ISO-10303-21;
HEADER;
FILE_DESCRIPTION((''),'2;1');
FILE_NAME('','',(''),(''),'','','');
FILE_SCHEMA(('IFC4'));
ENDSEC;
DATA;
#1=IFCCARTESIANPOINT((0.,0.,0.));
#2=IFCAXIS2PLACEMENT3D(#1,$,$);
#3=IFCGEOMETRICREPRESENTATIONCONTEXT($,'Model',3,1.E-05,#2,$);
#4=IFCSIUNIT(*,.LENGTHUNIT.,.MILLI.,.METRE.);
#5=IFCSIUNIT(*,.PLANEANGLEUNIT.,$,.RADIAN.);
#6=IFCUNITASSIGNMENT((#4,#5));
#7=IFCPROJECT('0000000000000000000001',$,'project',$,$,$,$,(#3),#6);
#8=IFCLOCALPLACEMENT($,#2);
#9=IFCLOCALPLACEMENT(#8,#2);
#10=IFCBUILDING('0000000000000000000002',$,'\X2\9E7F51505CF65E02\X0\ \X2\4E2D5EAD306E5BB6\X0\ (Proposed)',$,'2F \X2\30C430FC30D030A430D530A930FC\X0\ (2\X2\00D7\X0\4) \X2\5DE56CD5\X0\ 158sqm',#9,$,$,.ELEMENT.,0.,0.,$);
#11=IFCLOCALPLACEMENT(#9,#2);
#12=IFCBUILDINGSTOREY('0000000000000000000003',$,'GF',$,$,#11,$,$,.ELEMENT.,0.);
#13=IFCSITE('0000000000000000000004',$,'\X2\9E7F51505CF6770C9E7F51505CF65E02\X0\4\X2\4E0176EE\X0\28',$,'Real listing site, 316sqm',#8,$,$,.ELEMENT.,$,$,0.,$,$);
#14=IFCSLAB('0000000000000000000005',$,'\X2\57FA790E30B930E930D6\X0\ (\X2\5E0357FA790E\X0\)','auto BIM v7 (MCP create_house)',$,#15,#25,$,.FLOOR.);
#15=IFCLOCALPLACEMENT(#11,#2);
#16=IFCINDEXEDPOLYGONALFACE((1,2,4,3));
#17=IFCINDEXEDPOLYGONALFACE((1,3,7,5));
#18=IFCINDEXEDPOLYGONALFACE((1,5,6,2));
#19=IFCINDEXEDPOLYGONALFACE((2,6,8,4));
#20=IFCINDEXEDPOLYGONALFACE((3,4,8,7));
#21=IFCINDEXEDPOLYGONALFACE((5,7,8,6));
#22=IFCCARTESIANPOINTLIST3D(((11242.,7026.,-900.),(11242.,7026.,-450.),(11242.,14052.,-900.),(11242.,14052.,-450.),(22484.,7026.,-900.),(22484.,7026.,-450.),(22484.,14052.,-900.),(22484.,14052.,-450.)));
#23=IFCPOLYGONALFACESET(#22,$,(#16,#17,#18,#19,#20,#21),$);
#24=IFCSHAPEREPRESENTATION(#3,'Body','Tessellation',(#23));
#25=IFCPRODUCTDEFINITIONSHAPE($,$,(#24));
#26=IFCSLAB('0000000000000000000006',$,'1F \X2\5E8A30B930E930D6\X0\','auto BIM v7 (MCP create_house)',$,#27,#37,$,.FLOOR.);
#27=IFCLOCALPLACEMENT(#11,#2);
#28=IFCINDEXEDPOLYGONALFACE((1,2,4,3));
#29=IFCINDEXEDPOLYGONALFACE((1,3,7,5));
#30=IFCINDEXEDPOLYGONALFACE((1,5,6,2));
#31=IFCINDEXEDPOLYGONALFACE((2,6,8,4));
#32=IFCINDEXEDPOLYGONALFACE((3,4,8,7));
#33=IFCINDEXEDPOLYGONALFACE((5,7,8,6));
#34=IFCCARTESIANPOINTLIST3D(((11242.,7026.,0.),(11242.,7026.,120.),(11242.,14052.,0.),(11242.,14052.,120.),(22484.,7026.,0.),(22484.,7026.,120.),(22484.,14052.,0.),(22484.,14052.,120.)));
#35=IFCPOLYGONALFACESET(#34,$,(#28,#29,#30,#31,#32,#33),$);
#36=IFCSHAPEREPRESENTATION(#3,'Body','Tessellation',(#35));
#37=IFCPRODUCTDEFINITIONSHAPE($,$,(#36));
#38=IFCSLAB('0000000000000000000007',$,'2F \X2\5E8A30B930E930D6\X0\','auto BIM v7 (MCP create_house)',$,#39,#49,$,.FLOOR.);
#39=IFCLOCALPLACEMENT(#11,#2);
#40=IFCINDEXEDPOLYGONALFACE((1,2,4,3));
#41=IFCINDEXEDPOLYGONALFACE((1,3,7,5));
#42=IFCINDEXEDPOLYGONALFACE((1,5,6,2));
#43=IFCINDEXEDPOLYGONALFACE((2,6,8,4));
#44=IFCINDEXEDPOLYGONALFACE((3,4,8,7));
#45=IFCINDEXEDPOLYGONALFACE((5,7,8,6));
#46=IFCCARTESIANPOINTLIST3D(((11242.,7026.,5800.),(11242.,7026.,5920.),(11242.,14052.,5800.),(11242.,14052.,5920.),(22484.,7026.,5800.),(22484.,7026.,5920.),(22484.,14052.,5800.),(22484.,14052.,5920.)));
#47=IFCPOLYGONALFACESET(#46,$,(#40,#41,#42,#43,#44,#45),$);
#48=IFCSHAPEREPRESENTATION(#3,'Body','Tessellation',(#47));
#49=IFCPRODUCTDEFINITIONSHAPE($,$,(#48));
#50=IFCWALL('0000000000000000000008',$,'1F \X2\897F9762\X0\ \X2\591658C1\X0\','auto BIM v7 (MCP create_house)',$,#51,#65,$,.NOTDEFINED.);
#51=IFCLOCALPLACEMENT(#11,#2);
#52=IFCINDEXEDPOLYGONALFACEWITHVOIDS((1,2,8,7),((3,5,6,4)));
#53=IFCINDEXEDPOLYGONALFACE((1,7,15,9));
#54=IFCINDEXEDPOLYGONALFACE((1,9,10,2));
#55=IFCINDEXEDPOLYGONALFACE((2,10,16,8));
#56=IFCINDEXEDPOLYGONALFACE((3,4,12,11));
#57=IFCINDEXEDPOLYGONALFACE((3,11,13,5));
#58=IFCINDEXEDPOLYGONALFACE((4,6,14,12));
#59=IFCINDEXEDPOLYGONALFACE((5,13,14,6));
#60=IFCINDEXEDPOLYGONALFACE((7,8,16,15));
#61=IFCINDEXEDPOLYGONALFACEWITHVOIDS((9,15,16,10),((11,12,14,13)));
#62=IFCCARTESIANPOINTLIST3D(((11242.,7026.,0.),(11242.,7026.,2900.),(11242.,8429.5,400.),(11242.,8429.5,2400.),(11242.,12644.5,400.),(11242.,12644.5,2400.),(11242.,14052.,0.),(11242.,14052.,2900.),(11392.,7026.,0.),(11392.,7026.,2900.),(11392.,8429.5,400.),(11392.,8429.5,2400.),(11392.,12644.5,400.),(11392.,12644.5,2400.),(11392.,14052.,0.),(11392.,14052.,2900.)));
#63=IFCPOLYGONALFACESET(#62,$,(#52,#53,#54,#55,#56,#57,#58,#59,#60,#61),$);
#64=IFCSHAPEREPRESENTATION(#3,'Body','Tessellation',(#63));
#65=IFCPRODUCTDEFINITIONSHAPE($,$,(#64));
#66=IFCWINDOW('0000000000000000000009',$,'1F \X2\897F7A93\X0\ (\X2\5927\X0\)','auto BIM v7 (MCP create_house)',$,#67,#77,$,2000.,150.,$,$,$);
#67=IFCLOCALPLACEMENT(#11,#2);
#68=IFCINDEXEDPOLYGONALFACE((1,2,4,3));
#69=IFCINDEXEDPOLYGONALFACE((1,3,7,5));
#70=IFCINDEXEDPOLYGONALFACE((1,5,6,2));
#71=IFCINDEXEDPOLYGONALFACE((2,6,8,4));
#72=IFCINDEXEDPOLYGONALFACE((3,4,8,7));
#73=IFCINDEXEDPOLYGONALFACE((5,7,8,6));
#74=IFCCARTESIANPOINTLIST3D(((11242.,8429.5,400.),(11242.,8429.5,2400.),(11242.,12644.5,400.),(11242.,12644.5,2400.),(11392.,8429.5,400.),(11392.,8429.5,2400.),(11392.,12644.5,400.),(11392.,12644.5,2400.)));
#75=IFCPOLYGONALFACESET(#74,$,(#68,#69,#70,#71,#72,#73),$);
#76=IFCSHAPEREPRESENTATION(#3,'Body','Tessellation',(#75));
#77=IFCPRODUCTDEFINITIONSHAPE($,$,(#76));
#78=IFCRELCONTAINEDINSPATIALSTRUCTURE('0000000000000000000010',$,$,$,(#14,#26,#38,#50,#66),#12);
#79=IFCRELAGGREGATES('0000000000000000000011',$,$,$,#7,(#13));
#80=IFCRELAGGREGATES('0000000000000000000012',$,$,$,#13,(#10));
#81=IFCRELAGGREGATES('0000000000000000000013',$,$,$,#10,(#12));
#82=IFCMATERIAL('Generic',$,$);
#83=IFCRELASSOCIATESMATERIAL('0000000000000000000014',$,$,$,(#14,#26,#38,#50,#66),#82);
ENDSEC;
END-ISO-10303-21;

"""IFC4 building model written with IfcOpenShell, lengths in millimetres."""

from ifc_helpers import new_model, si_unit, frame, frame_2d, origin, place, context, project, spatial, rectangle, extrude, material, element, fill, save


model = new_model("IFC4")

# Units and contexts
model_context = context("Model", 3, precision=1e-05, world=origin())
ifc_project = project(units=[si_unit("LENGTHUNIT", "METRE", prefix="MILLI"), si_unit("PLANEANGLEUNIT", "RADIAN")], contexts=[model_context])

# Site, building, storey
site_placement = place(None, origin())
site = spatial("IfcSite", under=ifc_project, at=site_placement, Name="鹿児島県鹿児島市4丁目28", ObjectType="Real listing site, 316sqm", CompositionType="ELEMENT", RefElevation=0.0)
building_placement = place(site_placement, origin())
building = spatial("IfcBuilding", under=site, at=building_placement, Name="鹿児島市 中庭の家 (Proposed)", ObjectType="2F ツーバイフォー (2×4) 工法 158sqm", CompositionType="ELEMENT", ElevationOfRefHeight=0.0, ElevationOfTerrain=0.0)
storey_placement = place(building_placement, origin())
storey = spatial("IfcBuildingStorey", under=building, at=storey_placement, Name="GF", CompositionType="ELEMENT", Elevation=0.0)

# Slabs
ifc_material = material(Name="Generic")
slab_1_placement = place(storey_placement, frame((5621.0, 3513.0, -450.0)))
element("IfcSlab", 1, at=slab_1_placement, inside=storey, material=ifc_material, Name="基礎スラブ (布基礎)", Description="auto BIM v7 (MCP create_house)", PredefinedType="FLOOR", context=model_context, shape_type="SweptSolid", body=[
    extrude(rectangle(XDim=11242.0, YDim=7026.0, at=frame_2d((5621.0, 3513.0))), frame((5621.0, 3513.0, -450.0)), (0.0, 0.0, 1.0), 450.0),
])
slab_2_placement = place(storey_placement, frame((5621.0, 3513.0, 0.0)))
element("IfcSlab", 2, at=slab_2_placement, inside=storey, material=ifc_material, Name="1F 床スラブ", Description="auto BIM v7 (MCP create_house)", PredefinedType="FLOOR", context=model_context, shape_type="SweptSolid", body=[
    extrude(rectangle(XDim=11242.0, YDim=7026.0, at=frame_2d((5621.0, 3513.0))), frame((5621.0, 3513.0, 0.0)), (0.0, 0.0, 1.0), 120.0),
])
slab_3_placement = place(storey_placement, frame((5621.0, 3513.0, 2900.0)))
element("IfcSlab", 3, at=slab_3_placement, inside=storey, material=ifc_material, Name="2F 床スラブ", Description="auto BIM v7 (MCP create_house)", PredefinedType="FLOOR", context=model_context, shape_type="SweptSolid", body=[
    extrude(rectangle(XDim=11242.0, YDim=7026.0, at=frame_2d((5621.0, 3513.0))), frame((5621.0, 3513.0, 2900.0)), (0.0, 0.0, 1.0), 120.0),
])

# Wall, opening, window
wall_1_placement = place(storey_placement, frame((5621.0, 3513.0, 0.0)))
wall_1 = element("IfcWall", 4, at=wall_1_placement, inside=storey, material=ifc_material, Name="1F 西面 外壁", Description="auto BIM v7 (MCP create_house)", PredefinedType="NOTDEFINED", context=model_context, shape_type="SweptSolid", body=[
    extrude(rectangle(XDim=150.0, YDim=7026.0, at=frame_2d((75.0, 3513.0))), frame((5621.0, 3513.0, 0.0)), (0.0, 0.0, 1.0), 2900.0),
])
opening_1_placement = place(storey_placement, frame((5621.0, 4215.0, 200.0)))
opening_1 = element("IfcOpeningElement", 5, at=opening_1_placement, cuts=wall_1, PredefinedType="NOTDEFINED", context=model_context, shape_type="SweptSolid", body=[
    extrude(rectangle(XDim=150.0, YDim=4215.0, at=frame_2d((75.0, 2107.0))), frame((5621.0, 4215.0, 200.0)), (0.0, 0.0, 1.0), 2000.0),
])
window_1_placement = place(storey_placement, frame((5621.0, 4215.0, 200.0)))
window_1 = element("IfcWindow", 6, at=window_1_placement, inside=storey, material=ifc_material, Name="1F 西窓 (大)", Description="auto BIM v7 (MCP create_house)", OverallHeight=2000.0, OverallWidth=150.0, context=model_context, shape_type="SweptSolid", body=[
    extrude(rectangle(XDim=150.0, YDim=4215.0, at=frame_2d((75.0, 2107.0))), frame((5621.0, 4215.0, 200.0)), (0.0, 0.0, 1.0), 2000.0),
])
fill(opening_1, window_1)

save(model, "model.ifc")
